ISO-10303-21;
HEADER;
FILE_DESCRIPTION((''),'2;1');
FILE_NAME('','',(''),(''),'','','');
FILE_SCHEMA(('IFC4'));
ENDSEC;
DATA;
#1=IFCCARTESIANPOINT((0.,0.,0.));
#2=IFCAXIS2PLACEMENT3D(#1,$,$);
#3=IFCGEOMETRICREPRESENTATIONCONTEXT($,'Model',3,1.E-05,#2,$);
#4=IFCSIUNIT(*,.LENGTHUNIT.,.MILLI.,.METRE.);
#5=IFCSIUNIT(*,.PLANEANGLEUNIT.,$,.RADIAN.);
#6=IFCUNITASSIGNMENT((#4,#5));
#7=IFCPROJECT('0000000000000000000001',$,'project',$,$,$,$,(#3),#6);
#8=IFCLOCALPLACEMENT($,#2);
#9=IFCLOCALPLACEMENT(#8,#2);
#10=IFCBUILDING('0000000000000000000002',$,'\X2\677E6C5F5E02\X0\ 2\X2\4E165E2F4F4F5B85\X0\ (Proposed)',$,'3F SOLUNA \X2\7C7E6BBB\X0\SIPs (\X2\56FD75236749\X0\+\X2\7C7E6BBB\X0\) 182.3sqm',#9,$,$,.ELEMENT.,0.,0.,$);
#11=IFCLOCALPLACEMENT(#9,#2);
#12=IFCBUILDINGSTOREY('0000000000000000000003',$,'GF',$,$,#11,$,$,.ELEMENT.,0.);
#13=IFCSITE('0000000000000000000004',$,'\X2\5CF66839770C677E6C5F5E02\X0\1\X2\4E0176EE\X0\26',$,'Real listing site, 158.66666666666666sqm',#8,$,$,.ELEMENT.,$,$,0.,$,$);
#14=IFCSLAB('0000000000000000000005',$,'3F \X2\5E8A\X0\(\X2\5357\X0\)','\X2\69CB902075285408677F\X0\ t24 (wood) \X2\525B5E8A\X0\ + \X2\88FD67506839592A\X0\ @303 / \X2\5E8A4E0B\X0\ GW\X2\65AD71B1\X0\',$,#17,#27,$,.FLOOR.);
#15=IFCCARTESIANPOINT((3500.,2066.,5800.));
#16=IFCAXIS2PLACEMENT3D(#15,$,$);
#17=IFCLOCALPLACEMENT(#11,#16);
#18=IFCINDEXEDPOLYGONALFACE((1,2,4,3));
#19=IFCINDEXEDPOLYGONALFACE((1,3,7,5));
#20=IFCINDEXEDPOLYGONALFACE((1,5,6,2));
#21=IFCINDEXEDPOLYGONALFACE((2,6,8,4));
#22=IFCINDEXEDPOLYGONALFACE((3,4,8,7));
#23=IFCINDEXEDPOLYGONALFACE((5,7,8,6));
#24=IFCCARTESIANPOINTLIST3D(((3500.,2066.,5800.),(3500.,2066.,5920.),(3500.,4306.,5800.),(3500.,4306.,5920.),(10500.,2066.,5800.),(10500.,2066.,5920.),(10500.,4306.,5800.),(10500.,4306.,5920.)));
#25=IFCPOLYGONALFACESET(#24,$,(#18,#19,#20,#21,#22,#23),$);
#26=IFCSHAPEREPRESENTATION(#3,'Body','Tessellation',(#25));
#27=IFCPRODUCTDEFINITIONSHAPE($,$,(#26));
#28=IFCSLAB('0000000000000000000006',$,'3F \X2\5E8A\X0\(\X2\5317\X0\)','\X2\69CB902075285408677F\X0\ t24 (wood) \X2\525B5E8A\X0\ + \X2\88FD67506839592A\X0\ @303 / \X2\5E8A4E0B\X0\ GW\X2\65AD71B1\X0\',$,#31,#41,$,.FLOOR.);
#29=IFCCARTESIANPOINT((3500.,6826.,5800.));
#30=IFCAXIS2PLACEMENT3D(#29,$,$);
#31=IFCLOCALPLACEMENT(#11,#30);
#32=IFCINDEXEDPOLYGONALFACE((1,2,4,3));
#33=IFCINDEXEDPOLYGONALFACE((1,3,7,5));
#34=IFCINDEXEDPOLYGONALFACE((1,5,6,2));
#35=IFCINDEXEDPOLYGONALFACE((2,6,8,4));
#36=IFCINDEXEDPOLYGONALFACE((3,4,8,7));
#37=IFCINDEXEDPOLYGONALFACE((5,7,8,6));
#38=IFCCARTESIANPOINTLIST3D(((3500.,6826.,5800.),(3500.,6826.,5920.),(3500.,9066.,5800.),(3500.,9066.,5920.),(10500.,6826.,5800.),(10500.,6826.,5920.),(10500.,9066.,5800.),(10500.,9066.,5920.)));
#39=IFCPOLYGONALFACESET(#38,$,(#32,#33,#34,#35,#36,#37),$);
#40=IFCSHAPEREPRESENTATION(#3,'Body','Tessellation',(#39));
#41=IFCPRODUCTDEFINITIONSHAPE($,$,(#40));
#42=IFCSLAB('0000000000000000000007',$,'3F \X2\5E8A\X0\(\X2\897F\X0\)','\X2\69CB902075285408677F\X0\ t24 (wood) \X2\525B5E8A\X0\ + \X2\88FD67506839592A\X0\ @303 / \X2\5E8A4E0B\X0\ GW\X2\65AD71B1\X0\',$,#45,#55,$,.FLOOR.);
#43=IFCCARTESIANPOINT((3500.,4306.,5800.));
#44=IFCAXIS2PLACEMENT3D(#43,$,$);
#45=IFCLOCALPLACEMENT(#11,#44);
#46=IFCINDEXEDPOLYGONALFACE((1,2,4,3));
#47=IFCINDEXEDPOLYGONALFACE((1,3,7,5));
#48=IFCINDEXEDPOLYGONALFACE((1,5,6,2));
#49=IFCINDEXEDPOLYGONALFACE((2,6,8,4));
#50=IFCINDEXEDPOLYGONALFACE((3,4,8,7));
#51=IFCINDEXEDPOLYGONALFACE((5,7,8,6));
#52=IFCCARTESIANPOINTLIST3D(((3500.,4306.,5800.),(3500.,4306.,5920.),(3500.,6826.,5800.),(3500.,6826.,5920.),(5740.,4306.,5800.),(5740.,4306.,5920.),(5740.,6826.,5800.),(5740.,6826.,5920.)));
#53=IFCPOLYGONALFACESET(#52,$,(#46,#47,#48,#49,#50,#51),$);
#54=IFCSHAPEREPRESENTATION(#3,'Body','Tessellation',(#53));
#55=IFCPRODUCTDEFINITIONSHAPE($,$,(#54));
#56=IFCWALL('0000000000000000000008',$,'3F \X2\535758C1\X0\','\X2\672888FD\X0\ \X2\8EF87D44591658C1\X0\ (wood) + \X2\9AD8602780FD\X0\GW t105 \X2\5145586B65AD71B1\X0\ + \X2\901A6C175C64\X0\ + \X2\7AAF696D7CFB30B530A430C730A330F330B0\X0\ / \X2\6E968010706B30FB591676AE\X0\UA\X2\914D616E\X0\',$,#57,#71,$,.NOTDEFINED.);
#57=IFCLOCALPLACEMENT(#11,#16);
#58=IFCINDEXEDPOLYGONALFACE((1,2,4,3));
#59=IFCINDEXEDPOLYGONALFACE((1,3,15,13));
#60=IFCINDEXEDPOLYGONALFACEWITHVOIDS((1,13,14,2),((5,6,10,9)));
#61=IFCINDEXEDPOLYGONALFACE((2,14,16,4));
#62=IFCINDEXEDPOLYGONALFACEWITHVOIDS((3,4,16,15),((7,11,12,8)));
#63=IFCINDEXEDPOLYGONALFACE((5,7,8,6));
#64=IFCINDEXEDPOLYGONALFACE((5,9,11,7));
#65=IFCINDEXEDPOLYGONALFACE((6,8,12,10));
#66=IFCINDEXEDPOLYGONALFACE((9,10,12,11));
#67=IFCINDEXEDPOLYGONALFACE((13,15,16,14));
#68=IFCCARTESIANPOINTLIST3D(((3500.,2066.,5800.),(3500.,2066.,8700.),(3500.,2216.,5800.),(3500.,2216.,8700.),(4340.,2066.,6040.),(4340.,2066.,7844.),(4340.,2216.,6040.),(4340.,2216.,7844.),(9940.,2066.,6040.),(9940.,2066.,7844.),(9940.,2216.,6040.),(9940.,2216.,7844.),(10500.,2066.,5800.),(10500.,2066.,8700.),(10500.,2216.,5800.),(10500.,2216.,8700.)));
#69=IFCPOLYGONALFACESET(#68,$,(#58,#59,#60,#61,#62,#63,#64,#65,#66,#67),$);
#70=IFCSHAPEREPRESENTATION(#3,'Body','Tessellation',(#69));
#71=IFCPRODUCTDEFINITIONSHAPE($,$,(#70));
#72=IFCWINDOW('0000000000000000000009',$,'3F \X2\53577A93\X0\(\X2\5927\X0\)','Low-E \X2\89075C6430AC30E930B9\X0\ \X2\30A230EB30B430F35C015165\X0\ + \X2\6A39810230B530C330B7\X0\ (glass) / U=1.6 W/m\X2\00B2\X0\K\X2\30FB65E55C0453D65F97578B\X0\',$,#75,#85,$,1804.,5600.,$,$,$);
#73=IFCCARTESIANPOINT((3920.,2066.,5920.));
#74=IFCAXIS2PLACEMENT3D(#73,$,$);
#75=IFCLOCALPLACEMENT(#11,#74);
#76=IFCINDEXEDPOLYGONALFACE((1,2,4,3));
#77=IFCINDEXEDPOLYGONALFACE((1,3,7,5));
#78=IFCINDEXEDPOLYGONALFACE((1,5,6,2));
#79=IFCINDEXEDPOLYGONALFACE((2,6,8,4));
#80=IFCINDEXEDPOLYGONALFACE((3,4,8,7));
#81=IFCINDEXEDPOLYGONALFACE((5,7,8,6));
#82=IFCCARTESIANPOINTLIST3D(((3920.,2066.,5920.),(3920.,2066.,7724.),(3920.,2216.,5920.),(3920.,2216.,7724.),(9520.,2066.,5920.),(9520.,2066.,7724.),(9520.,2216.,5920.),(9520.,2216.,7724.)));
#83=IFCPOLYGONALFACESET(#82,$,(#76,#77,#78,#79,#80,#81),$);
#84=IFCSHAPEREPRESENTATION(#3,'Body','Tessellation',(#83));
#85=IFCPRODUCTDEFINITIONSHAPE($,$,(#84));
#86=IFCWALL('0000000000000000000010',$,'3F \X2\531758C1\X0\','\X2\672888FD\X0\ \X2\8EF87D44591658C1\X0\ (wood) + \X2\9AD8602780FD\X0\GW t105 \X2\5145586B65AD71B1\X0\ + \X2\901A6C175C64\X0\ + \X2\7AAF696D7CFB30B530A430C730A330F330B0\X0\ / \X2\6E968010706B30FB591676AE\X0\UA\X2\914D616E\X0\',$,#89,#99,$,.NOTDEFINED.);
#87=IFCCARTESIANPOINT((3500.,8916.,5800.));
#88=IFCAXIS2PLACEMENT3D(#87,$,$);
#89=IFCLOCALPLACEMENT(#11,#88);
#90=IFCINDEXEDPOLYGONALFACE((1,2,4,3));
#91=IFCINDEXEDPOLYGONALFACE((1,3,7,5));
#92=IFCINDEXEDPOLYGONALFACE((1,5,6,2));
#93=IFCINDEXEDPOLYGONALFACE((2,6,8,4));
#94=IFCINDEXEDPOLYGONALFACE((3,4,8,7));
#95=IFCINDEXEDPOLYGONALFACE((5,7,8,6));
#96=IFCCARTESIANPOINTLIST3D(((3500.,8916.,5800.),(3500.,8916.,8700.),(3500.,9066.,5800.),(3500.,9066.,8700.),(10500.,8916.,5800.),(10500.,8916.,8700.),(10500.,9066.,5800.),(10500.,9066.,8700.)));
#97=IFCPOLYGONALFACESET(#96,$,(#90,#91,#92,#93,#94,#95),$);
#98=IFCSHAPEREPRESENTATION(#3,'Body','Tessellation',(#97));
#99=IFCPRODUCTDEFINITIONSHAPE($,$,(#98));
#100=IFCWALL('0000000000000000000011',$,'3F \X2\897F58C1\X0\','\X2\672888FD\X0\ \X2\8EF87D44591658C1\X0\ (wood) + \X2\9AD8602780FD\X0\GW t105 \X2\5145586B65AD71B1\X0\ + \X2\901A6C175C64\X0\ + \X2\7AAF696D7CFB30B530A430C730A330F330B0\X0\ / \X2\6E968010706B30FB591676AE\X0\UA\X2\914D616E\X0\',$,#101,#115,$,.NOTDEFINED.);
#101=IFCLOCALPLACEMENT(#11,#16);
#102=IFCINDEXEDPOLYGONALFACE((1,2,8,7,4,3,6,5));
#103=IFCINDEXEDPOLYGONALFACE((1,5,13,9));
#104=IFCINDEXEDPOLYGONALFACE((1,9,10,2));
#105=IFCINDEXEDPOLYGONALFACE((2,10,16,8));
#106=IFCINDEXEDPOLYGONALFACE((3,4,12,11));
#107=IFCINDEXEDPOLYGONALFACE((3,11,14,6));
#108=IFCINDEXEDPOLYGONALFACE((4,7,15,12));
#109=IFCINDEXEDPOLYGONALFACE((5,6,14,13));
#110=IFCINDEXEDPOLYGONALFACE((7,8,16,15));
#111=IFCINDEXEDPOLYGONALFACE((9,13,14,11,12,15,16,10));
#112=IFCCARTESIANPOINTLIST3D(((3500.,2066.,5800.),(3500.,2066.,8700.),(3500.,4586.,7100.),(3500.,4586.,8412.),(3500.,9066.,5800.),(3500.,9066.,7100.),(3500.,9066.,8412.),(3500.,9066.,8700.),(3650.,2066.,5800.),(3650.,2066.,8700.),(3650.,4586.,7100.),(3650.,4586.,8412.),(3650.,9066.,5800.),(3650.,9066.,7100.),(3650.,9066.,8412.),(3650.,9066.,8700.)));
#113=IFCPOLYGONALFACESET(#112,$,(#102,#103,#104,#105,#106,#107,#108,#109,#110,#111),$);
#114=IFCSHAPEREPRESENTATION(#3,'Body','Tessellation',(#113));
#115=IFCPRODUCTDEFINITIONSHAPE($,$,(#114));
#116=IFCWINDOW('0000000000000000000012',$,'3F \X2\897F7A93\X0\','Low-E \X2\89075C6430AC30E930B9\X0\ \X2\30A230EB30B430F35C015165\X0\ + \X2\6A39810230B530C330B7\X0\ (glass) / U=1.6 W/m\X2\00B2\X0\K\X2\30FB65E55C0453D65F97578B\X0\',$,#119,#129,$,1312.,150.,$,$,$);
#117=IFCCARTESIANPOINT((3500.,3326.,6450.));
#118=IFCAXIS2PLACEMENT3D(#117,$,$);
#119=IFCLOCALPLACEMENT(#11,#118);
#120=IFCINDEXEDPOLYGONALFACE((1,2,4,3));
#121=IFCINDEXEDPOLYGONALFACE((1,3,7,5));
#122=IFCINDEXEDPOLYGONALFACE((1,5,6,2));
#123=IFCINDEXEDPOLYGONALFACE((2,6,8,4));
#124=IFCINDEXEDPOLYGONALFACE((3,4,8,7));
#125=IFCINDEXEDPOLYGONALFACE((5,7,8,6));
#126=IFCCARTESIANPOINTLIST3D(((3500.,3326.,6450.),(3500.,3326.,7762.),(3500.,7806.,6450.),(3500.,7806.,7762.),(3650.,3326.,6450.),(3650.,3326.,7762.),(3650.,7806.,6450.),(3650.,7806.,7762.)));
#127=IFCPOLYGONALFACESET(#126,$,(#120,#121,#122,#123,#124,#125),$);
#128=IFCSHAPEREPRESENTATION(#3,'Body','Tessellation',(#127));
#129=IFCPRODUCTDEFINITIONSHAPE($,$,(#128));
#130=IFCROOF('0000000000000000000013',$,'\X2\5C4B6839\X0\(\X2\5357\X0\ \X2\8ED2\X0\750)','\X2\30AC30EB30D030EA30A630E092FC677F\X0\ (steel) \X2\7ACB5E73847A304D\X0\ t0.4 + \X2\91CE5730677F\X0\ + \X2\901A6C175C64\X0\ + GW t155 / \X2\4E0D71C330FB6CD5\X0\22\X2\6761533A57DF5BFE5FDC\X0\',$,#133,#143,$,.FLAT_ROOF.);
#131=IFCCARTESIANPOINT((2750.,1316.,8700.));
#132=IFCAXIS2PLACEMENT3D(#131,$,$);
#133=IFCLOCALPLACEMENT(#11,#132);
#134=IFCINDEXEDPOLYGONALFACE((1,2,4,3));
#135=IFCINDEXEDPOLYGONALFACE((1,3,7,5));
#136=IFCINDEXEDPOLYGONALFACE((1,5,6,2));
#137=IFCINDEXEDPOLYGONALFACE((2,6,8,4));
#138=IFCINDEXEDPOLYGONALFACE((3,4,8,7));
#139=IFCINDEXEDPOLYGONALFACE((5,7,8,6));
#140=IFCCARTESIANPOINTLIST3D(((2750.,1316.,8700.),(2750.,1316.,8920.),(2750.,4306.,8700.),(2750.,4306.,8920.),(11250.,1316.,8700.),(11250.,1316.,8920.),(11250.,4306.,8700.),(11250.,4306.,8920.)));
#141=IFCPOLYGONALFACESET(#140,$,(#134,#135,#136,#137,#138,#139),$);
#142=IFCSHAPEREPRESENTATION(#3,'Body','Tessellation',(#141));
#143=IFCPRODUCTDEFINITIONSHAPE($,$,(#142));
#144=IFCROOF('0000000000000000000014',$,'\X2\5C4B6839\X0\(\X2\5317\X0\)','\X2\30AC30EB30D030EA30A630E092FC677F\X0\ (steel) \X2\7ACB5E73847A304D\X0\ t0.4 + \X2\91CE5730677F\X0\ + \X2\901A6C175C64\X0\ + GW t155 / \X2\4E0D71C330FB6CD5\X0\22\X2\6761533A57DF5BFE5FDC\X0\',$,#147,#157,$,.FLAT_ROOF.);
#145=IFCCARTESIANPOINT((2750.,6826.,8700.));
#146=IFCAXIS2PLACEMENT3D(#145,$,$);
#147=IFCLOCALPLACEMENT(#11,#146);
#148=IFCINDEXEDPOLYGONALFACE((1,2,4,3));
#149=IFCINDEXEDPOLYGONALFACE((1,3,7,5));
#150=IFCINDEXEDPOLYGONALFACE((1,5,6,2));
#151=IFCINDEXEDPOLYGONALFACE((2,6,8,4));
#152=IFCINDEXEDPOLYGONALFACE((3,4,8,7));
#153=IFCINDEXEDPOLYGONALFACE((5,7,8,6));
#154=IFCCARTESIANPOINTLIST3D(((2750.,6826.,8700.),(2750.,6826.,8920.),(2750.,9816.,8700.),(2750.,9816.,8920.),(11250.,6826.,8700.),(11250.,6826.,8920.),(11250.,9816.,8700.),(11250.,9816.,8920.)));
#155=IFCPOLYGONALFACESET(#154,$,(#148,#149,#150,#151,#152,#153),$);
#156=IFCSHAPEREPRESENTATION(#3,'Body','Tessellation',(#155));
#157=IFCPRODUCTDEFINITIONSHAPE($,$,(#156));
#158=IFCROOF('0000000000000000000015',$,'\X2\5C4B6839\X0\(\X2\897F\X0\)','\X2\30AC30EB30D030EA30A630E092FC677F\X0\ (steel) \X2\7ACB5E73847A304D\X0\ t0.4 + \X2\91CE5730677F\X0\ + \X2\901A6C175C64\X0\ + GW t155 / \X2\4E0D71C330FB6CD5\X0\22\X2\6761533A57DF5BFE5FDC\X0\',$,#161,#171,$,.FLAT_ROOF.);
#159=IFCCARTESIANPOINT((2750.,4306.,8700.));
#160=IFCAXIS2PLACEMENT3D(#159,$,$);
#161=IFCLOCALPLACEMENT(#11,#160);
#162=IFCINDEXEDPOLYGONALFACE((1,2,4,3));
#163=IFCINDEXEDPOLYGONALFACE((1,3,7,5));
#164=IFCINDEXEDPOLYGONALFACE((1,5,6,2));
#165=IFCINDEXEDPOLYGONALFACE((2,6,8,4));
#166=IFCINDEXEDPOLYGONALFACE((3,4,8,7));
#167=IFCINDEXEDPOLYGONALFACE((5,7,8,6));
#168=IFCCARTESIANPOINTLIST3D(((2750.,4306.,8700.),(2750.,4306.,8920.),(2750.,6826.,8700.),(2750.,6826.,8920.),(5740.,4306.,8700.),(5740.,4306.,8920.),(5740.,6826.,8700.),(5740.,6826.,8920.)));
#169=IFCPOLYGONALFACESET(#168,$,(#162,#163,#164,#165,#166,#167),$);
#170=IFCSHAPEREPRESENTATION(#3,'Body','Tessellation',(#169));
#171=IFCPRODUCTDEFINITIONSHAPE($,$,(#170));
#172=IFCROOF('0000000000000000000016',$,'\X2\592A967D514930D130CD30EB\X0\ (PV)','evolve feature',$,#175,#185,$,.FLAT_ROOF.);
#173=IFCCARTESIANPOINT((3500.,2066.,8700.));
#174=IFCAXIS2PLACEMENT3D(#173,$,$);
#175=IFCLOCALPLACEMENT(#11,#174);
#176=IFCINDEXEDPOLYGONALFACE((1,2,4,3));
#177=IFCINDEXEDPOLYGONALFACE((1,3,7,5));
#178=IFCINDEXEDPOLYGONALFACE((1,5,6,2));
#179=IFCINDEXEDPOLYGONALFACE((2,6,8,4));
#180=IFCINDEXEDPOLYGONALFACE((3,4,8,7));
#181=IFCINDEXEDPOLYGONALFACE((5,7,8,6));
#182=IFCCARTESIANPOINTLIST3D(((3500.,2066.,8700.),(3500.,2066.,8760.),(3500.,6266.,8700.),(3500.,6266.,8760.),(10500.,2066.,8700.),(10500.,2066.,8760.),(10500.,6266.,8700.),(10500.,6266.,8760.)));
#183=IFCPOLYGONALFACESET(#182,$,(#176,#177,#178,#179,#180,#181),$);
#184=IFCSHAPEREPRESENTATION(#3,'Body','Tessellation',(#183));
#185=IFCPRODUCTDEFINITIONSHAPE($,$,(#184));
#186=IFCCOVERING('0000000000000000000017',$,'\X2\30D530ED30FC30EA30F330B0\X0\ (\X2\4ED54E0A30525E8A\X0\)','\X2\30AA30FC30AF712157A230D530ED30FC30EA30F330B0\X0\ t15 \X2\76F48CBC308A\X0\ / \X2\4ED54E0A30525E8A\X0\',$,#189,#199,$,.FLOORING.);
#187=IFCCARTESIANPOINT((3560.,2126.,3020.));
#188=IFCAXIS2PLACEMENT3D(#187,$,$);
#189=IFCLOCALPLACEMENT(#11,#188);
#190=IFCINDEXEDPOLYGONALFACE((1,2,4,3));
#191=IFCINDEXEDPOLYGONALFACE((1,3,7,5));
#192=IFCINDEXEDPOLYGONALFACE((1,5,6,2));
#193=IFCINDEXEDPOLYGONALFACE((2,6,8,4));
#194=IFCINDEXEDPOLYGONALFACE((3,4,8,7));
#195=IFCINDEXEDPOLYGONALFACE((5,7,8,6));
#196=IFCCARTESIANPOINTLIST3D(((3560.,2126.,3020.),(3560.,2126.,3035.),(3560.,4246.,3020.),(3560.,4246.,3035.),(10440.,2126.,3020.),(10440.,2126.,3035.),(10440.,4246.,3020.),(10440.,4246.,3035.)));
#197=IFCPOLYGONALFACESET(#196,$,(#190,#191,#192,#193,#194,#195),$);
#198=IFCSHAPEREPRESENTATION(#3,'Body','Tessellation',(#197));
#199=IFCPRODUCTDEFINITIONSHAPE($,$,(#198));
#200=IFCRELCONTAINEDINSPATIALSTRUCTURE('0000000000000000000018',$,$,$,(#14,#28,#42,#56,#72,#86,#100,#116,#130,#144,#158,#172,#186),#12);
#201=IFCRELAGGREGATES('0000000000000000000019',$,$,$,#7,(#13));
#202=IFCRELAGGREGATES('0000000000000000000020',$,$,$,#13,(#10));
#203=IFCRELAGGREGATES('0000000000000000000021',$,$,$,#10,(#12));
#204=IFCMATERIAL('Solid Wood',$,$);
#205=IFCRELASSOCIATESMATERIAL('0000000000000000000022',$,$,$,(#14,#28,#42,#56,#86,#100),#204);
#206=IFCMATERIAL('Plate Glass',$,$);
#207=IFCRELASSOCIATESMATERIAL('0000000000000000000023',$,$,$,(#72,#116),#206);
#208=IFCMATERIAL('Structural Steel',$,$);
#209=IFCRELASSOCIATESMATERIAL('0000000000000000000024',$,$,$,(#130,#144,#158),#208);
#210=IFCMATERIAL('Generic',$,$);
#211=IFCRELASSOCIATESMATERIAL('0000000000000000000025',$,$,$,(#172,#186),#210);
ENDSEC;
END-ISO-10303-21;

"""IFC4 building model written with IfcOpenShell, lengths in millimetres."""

from ifc_helpers import new_model, si_unit, frame, frame_2d, origin, place, context, project, spatial, rectangle, extrude, material, element, fill, save


model = new_model("IFC4")

# Units and contexts
model_context = context("Model", 3, precision=1e-05, world=origin())
ifc_project = project(units=[si_unit("LENGTHUNIT", "METRE", prefix="MILLI"), si_unit("PLANEANGLEUNIT", "RADIAN")], contexts=[model_context])

# Site, building, storey
site_placement = place(None, origin())
site = spatial("IfcSite", under=ifc_project, at=site_placement, Name="島根県松江市1丁目26", ObjectType="Real listing site, 158.66666666666666sqm", CompositionType="ELEMENT", RefElevation=0.0)
building_placement = place(site_placement, origin())
building = spatial("IfcBuilding", under=site, at=building_placement, Name="松江市 2世帯住宅 (Proposed)", ObjectType="3F SOLUNA 籾殻SIPs (国産杉+籾殻) 182.3sqm", CompositionType="ELEMENT", ElevationOfRefHeight=0.0, ElevationOfTerrain=0.0)
storey_placement = place(building_placement, origin())
storey = spatial("IfcBuildingStorey", under=building, at=storey_placement, Name="GF", CompositionType="ELEMENT", Elevation=0.0)

# Slabs
ifc_material_1 = material(Name="Solid Wood")
slab_1_placement = place(storey_placement, frame((3500.0, 2066.0, 5800.0)))
element("IfcSlab", 1, at=slab_1_placement, inside=storey, material=ifc_material_1, Name="3F 床(南)", Description="構造用合板 t24 (wood) 剛床 + 製材根太 @303 / 床下 GW断熱", PredefinedType="FLOOR", context=model_context, shape_type="SweptSolid", body=[
    extrude(rectangle(XDim=7000.0, YDim=2240.0, at=frame_2d((3500.0, 1120.0))), frame((3500.0, 2066.0, 5800.0)), (0.0, 0.0, 1.0), 120.0),
])
slab_2_placement = place(storey_placement, frame((3500.0, 6826.0, 5800.0)))
element("IfcSlab", 2, at=slab_2_placement, inside=storey, material=ifc_material_1, Name="3F 床(北)", Description="構造用合板 t24 (wood) 剛床 + 製材根太 @303 / 床下 GW断熱", PredefinedType="FLOOR", context=model_context, shape_type="SweptSolid", body=[
    extrude(rectangle(XDim=7000.0, YDim=2240.0, at=frame_2d((3500.0, 1120.0))), frame((3500.0, 6826.0, 5800.0)), (0.0, 0.0, 1.0), 120.0),
])
slab_3_placement = place(storey_placement, frame((3500.0, 4306.0, 5800.0)))
element("IfcSlab", 3, at=slab_3_placement, inside=storey, material=ifc_material_1, Name="3F 床(西)", Description="構造用合板 t24 (wood) 剛床 + 製材根太 @303 / 床下 GW断熱", PredefinedType="FLOOR", context=model_context, shape_type="SweptSolid", body=[
    extrude(rectangle(XDim=2240.0, YDim=2520.0, at=frame_2d((1120.0, 1260.0))), frame((3500.0, 4306.0, 5800.0)), (0.0, 0.0, 1.0), 120.0),
])

# Wall, opening, window
wall_1_placement = place(storey_placement, frame((3500.0, 2066.0, 5800.0)))
wall_1 = element("IfcWall", 4, at=wall_1_placement, inside=storey, material=ifc_material_1, Name="3F 南壁", Description="木製 軸組外壁 (wood) + 高性能GW t105 充填断熱 + 通気層 + 窯業系サイディング / 準耐火・外皮UA配慮", PredefinedType="NOTDEFINED", context=model_context, shape_type="SweptSolid", body=[
    extrude(rectangle(XDim=7000.0, YDim=150.0, at=frame_2d((3500.0, 75.0))), frame((3500.0, 2066.0, 5800.0)), (0.0, 0.0, 1.0), 2900.0),
])
opening_1_placement = place(storey_placement, frame((3920.0, 2066.0, 5920.0)))
opening_1 = element("IfcOpeningElement", 5, at=opening_1_placement, cuts=wall_1, PredefinedType="NOTDEFINED", context=model_context, shape_type="SweptSolid", body=[
    extrude(rectangle(XDim=5600.0, YDim=150.0, at=frame_2d((2800.0, 75.0))), frame((3920.0, 2066.0, 5920.0)), (0.0, 0.0, 1.0), 1804.0),
])
ifc_material_2 = material(Name="Plate Glass")
window_1_placement = place(storey_placement, frame((3920.0, 2066.0, 5920.0)))
window_1 = element("IfcWindow", 6, at=window_1_placement, inside=storey, material=ifc_material_2, Name="3F 南窓(大)", Description="Low-E 複層ガラス アルゴン封入 + 樹脂サッシ (glass) / U=1.6 W/m²K・日射取得型", OverallHeight=1804.0, OverallWidth=5600.0, context=model_context, shape_type="SweptSolid", body=[
    extrude(rectangle(XDim=5600.0, YDim=150.0, at=frame_2d((2800.0, 75.0))), frame((3920.0, 2066.0, 5920.0)), (0.0, 0.0, 1.0), 1804.0),
])
fill(opening_1, window_1)

# Wall
wall_2_placement = place(storey_placement, frame((3500.0, 8916.0, 5800.0)))
element("IfcWall", 7, at=wall_2_placement, inside=storey, material=ifc_material_1, Name="3F 北壁", Description="木製 軸組外壁 (wood) + 高性能GW t105 充填断熱 + 通気層 + 窯業系サイディング / 準耐火・外皮UA配慮", PredefinedType="NOTDEFINED", context=model_context, shape_type="SweptSolid", body=[
    extrude(rectangle(XDim=7000.0, YDim=150.0, at=frame_2d((3500.0, 75.0))), frame((3500.0, 8916.0, 5800.0)), (0.0, 0.0, 1.0), 2900.0),
])

# Wall, opening, window
wall_3_placement = place(storey_placement, frame((3500.0, 2066.0, 5800.0)))
wall_3 = element("IfcWall", 8, at=wall_3_placement, inside=storey, material=ifc_material_1, Name="3F 西壁", Description="木製 軸組外壁 (wood) + 高性能GW t105 充填断熱 + 通気層 + 窯業系サイディング / 準耐火・外皮UA配慮", PredefinedType="NOTDEFINED", context=model_context, shape_type="SweptSolid", body=[
    extrude(rectangle(XDim=150.0, YDim=7000.0, at=frame_2d((75.0, 3500.0))), frame((3500.0, 2066.0, 5800.0)), (0.0, 0.0, 1.0), 2900.0),
])
opening_2_placement = place(storey_placement, frame((3500.0, 3326.0, 6450.0)))
opening_2 = element("IfcOpeningElement", 9, at=opening_2_placement, cuts=wall_3, PredefinedType="NOTDEFINED", context=model_context, shape_type="SweptSolid", body=[
    extrude(rectangle(XDim=150.0, YDim=4480.0, at=frame_2d((75.0, 2240.0))), frame((3500.0, 3326.0, 6450.0)), (0.0, 0.0, 1.0), 1312.0),
])
window_2_placement = place(storey_placement, frame((3500.0, 3326.0, 6450.0)))
window_2 = element("IfcWindow", 10, at=window_2_placement, inside=storey, material=ifc_material_2, Name="3F 西窓", Description="Low-E 複層ガラス アルゴン封入 + 樹脂サッシ (glass) / U=1.6 W/m²K・日射取得型", OverallHeight=1312.0, OverallWidth=150.0, context=model_context, shape_type="SweptSolid", body=[
    extrude(rectangle(XDim=150.0, YDim=4480.0, at=frame_2d((75.0, 2240.0))), frame((3500.0, 3326.0, 6450.0)), (0.0, 0.0, 1.0), 1312.0),
])
fill(opening_2, window_2)

# Roofs
ifc_material_3 = material(Name="Structural Steel")
roof_1_placement = place(storey_placement, frame((2750.0, 1316.0, 8700.0)))
element("IfcRoof", 11, at=roof_1_placement, inside=storey, material=ifc_material_3, Name="屋根(南 軒750)", Description="ガルバリウム鋼板 (steel) 立平葺き t0.4 + 野地板 + 通気層 + GW t155 / 不燃・法22条区域対応", PredefinedType="FLAT_ROOF", context=model_context, shape_type="SweptSolid", body=[
    extrude(rectangle(XDim=8500.0, YDim=2990.0, at=frame_2d((4250.0, 1495.0))), frame((2750.0, 1316.0, 8700.0)), (0.0, 0.0, 1.0), 220.0),
])
roof_2_placement = place(storey_placement, frame((2750.0, 6826.0, 8700.0)))
element("IfcRoof", 12, at=roof_2_placement, inside=storey, material=ifc_material_3, Name="屋根(北)", Description="ガルバリウム鋼板 (steel) 立平葺き t0.4 + 野地板 + 通気層 + GW t155 / 不燃・法22条区域対応", PredefinedType="FLAT_ROOF", context=model_context, shape_type="SweptSolid", body=[
    extrude(rectangle(XDim=8500.0, YDim=2990.0, at=frame_2d((4250.0, 1495.0))), frame((2750.0, 6826.0, 8700.0)), (0.0, 0.0, 1.0), 220.0),
])
roof_3_placement = place(storey_placement, frame((2750.0, 4306.0, 8700.0)))
element("IfcRoof", 13, at=roof_3_placement, inside=storey, material=ifc_material_3, Name="屋根(西)", Description="ガルバリウム鋼板 (steel) 立平葺き t0.4 + 野地板 + 通気層 + GW t155 / 不燃・法22条区域対応", PredefinedType="FLAT_ROOF", context=model_context, shape_type="SweptSolid", body=[
    extrude(rectangle(XDim=2990.0, YDim=2520.0, at=frame_2d((1495.0, 1260.0))), frame((2750.0, 4306.0, 8700.0)), (0.0, 0.0, 1.0), 220.0),
])
ifc_material_4 = material(Name="Generic")
roof_4_placement = place(storey_placement, frame((3500.0, 2066.0, 8700.0)))
element("IfcRoof", 14, at=roof_4_placement, inside=storey, material=ifc_material_4, Name="太陽光パネル (PV)", Description="evolve feature", PredefinedType="FLAT_ROOF", context=model_context, shape_type="SweptSolid", body=[
    extrude(rectangle(XDim=7000.0, YDim=4200.0, at=frame_2d((3500.0, 2100.0))), frame((3500.0, 2066.0, 8700.0)), (0.0, 0.0, 1.0), 60.0),
])

# Covering
covering_1_placement = place(storey_placement, frame((3560.0, 2126.0, 3020.0)))
element("IfcCovering", 15, at=covering_1_placement, inside=storey, material=ifc_material_4, Name="フローリング (仕上げ床)", Description="オーク無垢フローリング t15 直貼り / 仕上げ床", PredefinedType="FLOORING", context=model_context, shape_type="SweptSolid", body=[
    extrude(rectangle(XDim=6880.0, YDim=2120.0, at=frame_2d((3440.0, 1060.0))), frame((3560.0, 2126.0, 3020.0)), (0.0, 0.0, 1.0), 15.0),
])

save(model, "model.ifc")
